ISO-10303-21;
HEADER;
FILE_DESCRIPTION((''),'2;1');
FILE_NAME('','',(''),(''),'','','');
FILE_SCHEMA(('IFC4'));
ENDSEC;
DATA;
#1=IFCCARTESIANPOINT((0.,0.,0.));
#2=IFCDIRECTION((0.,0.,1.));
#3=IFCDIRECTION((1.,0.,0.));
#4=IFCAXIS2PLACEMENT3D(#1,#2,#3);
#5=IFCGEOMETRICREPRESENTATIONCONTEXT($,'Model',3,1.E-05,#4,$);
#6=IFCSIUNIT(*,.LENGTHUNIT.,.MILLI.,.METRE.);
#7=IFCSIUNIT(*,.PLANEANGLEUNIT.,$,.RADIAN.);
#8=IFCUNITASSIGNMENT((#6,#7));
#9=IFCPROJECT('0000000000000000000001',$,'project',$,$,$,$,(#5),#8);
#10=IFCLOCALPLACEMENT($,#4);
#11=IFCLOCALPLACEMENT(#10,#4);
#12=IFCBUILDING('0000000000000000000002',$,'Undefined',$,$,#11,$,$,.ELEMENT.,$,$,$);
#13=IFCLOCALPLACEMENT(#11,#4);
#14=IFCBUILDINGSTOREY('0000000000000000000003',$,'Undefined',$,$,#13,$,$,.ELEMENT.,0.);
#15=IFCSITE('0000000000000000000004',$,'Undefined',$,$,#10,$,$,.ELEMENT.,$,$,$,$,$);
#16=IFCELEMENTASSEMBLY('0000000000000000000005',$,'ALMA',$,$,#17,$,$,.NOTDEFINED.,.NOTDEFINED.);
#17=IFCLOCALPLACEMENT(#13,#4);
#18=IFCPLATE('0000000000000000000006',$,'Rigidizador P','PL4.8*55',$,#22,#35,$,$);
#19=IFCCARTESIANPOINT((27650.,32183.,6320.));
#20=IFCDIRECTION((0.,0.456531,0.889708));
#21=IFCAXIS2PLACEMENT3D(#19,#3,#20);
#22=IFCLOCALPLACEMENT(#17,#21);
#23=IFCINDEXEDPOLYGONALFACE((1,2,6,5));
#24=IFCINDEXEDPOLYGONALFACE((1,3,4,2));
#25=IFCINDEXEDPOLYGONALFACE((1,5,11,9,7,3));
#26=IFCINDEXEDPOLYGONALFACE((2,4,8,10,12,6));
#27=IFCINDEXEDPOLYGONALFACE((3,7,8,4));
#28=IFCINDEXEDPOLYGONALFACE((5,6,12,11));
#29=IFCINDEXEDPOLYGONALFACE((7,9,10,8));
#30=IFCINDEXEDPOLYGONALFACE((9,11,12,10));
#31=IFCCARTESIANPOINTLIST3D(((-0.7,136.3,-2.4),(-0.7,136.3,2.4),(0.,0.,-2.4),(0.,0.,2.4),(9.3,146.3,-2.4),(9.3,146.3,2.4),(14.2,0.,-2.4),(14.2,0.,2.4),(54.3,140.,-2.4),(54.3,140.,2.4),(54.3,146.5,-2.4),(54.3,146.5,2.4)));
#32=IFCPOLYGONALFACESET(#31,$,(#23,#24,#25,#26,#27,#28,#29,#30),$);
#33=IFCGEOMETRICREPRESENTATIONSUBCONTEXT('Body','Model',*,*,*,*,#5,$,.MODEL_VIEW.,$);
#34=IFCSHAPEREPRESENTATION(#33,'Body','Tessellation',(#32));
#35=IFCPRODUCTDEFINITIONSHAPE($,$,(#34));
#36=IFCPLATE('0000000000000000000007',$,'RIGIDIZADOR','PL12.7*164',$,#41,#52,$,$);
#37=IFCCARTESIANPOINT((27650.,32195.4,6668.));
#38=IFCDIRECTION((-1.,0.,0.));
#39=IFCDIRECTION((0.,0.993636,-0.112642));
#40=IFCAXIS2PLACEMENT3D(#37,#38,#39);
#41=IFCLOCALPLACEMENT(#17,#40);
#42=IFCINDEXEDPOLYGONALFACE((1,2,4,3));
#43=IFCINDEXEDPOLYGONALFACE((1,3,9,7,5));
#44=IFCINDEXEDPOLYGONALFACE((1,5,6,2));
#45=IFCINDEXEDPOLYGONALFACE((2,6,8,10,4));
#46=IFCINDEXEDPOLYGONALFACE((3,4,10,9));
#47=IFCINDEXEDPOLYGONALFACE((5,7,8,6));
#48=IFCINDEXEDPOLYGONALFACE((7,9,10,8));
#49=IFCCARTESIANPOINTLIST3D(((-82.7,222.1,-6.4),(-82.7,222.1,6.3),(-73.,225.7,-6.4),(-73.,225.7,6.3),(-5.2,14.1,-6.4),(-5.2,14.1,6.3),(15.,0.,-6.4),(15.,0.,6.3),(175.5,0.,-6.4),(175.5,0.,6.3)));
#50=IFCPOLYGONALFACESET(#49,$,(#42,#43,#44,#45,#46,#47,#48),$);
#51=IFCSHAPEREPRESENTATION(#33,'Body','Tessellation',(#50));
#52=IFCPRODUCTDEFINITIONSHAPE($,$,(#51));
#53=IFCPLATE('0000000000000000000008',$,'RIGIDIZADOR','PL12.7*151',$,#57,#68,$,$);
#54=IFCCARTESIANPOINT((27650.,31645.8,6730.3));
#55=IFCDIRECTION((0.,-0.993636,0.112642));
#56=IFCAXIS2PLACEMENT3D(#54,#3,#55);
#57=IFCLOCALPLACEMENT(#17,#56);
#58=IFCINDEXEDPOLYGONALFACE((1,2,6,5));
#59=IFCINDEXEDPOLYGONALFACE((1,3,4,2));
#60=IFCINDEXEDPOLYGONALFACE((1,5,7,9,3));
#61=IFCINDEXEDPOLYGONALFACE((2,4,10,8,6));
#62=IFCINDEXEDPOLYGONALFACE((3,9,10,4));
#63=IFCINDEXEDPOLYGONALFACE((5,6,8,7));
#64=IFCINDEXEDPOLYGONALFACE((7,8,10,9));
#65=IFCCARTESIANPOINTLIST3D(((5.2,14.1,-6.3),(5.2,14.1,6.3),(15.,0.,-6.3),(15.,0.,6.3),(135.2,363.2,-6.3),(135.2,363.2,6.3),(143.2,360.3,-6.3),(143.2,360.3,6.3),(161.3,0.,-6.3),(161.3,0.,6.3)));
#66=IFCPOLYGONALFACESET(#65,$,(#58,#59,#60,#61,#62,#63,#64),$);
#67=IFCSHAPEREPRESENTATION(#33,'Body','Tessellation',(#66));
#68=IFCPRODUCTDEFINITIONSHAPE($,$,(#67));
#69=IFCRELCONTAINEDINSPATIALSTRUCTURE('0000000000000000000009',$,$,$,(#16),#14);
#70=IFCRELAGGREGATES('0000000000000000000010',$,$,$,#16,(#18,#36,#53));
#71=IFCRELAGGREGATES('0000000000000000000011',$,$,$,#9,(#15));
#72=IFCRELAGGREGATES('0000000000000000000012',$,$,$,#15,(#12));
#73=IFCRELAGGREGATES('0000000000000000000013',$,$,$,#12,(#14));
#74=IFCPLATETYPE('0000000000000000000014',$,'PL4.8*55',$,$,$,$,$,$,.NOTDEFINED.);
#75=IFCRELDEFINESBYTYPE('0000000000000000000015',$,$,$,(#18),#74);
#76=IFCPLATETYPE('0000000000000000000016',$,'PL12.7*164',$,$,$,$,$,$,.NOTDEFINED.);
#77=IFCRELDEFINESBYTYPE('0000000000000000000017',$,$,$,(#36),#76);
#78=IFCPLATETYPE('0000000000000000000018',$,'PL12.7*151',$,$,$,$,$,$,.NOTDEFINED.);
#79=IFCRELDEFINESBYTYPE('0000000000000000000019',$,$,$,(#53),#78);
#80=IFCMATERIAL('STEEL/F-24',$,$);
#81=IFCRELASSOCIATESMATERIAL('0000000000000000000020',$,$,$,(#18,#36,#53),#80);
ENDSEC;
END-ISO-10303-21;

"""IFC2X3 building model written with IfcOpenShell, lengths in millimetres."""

from ifc_helpers import new_model, si_unit, frame, origin_with_axes, place, context, subcontext, project, spatial, polyline, outline, extrude, material, type_object, element, aggregate, save


model = new_model("IFC2X3")

# Units and contexts
model_context = context("Model", 3, precision=1e-05, world=origin_with_axes())
body_context = subcontext(model_context, "Body", "Model", "MODEL_VIEW")
ifc_project = project(units=[si_unit("LENGTHUNIT", "METRE", prefix="MILLI"), si_unit("PLANEANGLEUNIT", "RADIAN")], contexts=[model_context])

# Site, building, storey
site_placement = place(None, origin_with_axes())
site = spatial("IfcSite", under=ifc_project, at=site_placement, Name="Undefined", CompositionType="ELEMENT")
building_placement = place(site_placement, origin_with_axes())
building = spatial("IfcBuilding", under=site, at=building_placement, Name="Undefined", CompositionType="ELEMENT")
storey_placement = place(building_placement, origin_with_axes())
storey = spatial("IfcBuildingStorey", under=building, at=storey_placement, Name="Undefined", CompositionType="ELEMENT", Elevation=0.0)

# Shared definitions
ifc_material_1 = material(Name="STEEL/F-24")

# Element assembly, plate
assembly_1_placement = place(storey_placement, origin_with_axes())
assembly_1 = element("IfcElementAssembly", 1, at=assembly_1_placement, inside=storey, Name="ALMA", AssemblyPlace="NOTDEFINED", PredefinedType="NOTDEFINED")
plate_type_1 = type_object("IfcPlateType", Name="PL4.8*55", PredefinedType="NOTDEFINED")
plate_1_placement = place(assembly_1_placement, frame((27650.0, 32183.0, 6320.0), z_axis=(1.0, 0.0, 0.0), x_axis=(0.0, 0.456531, 0.889708)))
plate_1 = element("IfcPlate", 2, at=plate_1_placement, type_object=plate_type_1, material=ifc_material_1, Name="Rigidizador P", Description="PL4.8*55", context=body_context, shape_type="SweptSolid", body=[
    extrude(outline(polyline([(0.0, 0.0), (14.2, 0.0), (54.3, 140.0), (54.3, 146.5), (9.3, 146.3), (-0.7, 136.3), (0.0, 0.0)])), frame((0.0, 0.0, -2.4), z_axis=(0.0, 0.0, 1.0), x_axis=(1.0, 0.0, 0.0)), (0.0, 0.0, 1.0), 4.8),
])

# Plates
plate_type_2 = type_object("IfcPlateType", Name="PL12.7*164", PredefinedType="NOTDEFINED")
plate_2_placement = place(assembly_1_placement, frame((27650.0, 32195.4, 6668.0), z_axis=(-1.0, 0.0, 0.0), x_axis=(0.0, 0.993636, -0.112642)))
plate_2 = element("IfcPlate", 3, at=plate_2_placement, type_object=plate_type_2, material=ifc_material_1, Name="RIGIDIZADOR", Description="PL12.7*164", context=body_context, shape_type="SweptSolid", body=[
    extrude(outline(polyline([(-5.2, 14.1), (15.0, 0.0), (175.5, 0.0), (-73.0, 225.7), (-82.7, 222.1), (-5.2, 14.1)])), frame((0.0, 0.0, -6.3), z_axis=(0.0, 0.0, 1.0), x_axis=(1.0, 0.0, 0.0)), (0.0, 0.0, 1.0), 12.7),
])
plate_type_3 = type_object("IfcPlateType", Name="PL12.7*151", PredefinedType="NOTDEFINED")
plate_3_placement = place(assembly_1_placement, frame((27650.0, 31645.8, 6730.3), z_axis=(1.0, 0.0, 0.0), x_axis=(0.0, -0.993636, 0.112642)))
plate_3 = element("IfcPlate", 4, at=plate_3_placement, type_object=plate_type_3, material=ifc_material_1, Name="RIGIDIZADOR", Description="PL12.7*151", context=body_context, shape_type="SweptSolid", body=[
    extrude(outline(polyline([(5.2, 14.1), (15.0, 0.0), (161.3, 0.0), (143.2, 360.3), (135.2, 363.2), (5.2, 14.1)])), frame((0.0, 0.0, -6.3), z_axis=(0.0, 0.0, 1.0), x_axis=(1.0, 0.0, 0.0)), (0.0, 0.0, 1.0), 12.7),
])

aggregate(assembly_1, [plate_1, plate_2, plate_3])

save(model, "model.ifc")
